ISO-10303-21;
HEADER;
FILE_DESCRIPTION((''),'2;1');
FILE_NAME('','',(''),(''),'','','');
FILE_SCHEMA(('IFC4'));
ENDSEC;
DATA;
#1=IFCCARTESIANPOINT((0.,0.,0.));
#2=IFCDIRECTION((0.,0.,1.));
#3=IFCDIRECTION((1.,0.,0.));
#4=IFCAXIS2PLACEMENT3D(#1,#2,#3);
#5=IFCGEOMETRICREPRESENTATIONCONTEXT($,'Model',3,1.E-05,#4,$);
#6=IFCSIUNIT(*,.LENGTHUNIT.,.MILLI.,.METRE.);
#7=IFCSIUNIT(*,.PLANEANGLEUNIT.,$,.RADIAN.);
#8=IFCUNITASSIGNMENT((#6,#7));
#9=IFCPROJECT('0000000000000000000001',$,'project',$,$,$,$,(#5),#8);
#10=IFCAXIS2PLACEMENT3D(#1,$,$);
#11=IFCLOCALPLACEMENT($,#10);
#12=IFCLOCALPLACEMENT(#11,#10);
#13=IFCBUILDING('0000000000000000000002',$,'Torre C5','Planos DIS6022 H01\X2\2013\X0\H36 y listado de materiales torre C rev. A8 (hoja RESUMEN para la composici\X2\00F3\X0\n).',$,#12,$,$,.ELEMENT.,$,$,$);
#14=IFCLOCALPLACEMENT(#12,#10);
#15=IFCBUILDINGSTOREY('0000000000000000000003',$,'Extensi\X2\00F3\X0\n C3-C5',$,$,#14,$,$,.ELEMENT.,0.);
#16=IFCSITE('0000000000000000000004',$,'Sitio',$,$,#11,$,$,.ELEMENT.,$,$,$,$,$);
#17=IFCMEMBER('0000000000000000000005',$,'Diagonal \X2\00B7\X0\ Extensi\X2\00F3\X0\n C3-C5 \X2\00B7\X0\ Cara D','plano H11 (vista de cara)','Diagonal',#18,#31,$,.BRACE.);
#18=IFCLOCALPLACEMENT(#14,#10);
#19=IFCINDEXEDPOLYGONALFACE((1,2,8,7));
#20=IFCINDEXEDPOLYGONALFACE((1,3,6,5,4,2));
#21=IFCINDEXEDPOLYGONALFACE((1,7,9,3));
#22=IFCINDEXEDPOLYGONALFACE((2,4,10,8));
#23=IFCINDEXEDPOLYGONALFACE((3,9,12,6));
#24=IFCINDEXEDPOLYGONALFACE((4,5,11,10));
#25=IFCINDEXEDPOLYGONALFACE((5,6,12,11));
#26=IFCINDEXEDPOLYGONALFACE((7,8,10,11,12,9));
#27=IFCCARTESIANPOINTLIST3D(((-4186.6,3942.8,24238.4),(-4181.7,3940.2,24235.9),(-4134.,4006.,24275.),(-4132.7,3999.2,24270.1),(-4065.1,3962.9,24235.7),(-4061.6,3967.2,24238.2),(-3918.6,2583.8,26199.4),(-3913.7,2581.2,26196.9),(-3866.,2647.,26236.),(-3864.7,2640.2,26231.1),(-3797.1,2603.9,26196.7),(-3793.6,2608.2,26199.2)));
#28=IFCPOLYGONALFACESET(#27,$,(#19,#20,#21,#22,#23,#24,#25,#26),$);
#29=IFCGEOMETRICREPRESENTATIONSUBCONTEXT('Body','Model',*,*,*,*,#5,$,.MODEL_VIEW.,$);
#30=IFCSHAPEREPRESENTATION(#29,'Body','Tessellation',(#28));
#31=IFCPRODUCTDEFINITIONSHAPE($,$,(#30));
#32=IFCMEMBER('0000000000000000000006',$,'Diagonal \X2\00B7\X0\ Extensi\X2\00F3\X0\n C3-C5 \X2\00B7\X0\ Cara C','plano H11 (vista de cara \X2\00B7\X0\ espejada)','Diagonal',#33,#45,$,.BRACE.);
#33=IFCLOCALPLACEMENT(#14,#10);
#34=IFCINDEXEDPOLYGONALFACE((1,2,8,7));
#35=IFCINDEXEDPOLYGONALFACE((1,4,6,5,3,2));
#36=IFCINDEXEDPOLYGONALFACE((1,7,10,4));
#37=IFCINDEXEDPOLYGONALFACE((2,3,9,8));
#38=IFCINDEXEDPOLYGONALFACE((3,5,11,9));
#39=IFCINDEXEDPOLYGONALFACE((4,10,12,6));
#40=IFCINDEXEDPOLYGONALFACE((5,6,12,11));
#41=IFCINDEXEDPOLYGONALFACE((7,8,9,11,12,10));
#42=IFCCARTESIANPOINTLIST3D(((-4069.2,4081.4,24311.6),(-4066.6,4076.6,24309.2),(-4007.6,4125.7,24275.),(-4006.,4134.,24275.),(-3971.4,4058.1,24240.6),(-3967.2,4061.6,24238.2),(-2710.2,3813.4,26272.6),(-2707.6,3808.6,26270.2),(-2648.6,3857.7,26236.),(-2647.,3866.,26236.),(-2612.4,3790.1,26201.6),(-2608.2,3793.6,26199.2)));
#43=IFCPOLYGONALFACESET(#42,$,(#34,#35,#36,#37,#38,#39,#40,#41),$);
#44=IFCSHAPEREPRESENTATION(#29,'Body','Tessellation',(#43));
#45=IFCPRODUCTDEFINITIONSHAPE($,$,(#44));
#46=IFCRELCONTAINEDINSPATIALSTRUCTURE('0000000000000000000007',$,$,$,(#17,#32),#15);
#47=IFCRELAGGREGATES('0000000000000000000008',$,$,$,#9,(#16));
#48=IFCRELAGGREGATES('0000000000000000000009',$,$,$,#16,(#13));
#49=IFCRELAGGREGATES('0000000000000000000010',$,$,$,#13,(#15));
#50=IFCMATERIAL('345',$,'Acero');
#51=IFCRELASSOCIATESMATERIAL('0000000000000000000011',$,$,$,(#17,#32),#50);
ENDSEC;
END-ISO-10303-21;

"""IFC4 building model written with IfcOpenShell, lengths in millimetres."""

from ifc_helpers import new_model, si_unit, frame, frame_2d, origin, origin_with_axes, place, context, subcontext, project, spatial, l_section, extrude, material, element, save


model = new_model("IFC4")

# Units and contexts
model_context = context("Model", 3, precision=1e-05, world=origin_with_axes())
body_context = subcontext(model_context, "Body", "Model", "MODEL_VIEW")
ifc_project = project(units=[si_unit("LENGTHUNIT", "METRE", prefix="MILLI"), si_unit("PLANEANGLEUNIT", "RADIAN")], contexts=[model_context])

# Site, building, storey
site_placement = place(None, origin())
site = spatial("IfcSite", under=ifc_project, at=site_placement, Name="Sitio", CompositionType="ELEMENT")
building_placement = place(site_placement, origin())
building = spatial("IfcBuilding", under=site, at=building_placement, Name="Torre C5", Description="Planos DIS6022 H01–H36 y listado de materiales torre C rev. A8 (hoja RESUMEN para la composición).", CompositionType="ELEMENT")
storey_placement = place(building_placement, origin())
storey = spatial("IfcBuildingStorey", under=building, at=storey_placement, Name="Extensión C3-C5", CompositionType="ELEMENT", Elevation=0.0)

# Members
ifc_material_1 = material(Name="345", Category="Acero")
for number, where, z_axis, x_axis, name, description in (
    (1, (-3866.0, 2647.0, 26236.0), (-0.111626, 0.566042, -0.816784), (0.803983, -0.431647, -0.409013), "Diagonal · Extensión C3-C5 · Cara D", "plano H11 (vista de cara)"),
    (2, (-2647.0, 3866.0, 26236.0), (-0.566042, 0.111626, -0.816784), (0.431647, -0.803983, -0.409013), "Diagonal · Extensión C3-C5 · Cara C", "plano H11 (vista de cara · espejada)"),
):
    element("IfcMember", number, at=place(storey_placement, frame(where, z_axis=z_axis, x_axis=x_axis)), inside=storey, material=ifc_material_1, Name=name, Description=description, ObjectType="Diagonal", PredefinedType="BRACE", context=body_context, shape_type="SweptSolid", body=[
        extrude(l_section(Depth=90.0, Width=90.0, Thickness=6.0, at=frame_2d((45.0, 45.0))), None, (0.0, 0.0, 1.0), 2400.9),
    ])

save(model, "model.ifc")
